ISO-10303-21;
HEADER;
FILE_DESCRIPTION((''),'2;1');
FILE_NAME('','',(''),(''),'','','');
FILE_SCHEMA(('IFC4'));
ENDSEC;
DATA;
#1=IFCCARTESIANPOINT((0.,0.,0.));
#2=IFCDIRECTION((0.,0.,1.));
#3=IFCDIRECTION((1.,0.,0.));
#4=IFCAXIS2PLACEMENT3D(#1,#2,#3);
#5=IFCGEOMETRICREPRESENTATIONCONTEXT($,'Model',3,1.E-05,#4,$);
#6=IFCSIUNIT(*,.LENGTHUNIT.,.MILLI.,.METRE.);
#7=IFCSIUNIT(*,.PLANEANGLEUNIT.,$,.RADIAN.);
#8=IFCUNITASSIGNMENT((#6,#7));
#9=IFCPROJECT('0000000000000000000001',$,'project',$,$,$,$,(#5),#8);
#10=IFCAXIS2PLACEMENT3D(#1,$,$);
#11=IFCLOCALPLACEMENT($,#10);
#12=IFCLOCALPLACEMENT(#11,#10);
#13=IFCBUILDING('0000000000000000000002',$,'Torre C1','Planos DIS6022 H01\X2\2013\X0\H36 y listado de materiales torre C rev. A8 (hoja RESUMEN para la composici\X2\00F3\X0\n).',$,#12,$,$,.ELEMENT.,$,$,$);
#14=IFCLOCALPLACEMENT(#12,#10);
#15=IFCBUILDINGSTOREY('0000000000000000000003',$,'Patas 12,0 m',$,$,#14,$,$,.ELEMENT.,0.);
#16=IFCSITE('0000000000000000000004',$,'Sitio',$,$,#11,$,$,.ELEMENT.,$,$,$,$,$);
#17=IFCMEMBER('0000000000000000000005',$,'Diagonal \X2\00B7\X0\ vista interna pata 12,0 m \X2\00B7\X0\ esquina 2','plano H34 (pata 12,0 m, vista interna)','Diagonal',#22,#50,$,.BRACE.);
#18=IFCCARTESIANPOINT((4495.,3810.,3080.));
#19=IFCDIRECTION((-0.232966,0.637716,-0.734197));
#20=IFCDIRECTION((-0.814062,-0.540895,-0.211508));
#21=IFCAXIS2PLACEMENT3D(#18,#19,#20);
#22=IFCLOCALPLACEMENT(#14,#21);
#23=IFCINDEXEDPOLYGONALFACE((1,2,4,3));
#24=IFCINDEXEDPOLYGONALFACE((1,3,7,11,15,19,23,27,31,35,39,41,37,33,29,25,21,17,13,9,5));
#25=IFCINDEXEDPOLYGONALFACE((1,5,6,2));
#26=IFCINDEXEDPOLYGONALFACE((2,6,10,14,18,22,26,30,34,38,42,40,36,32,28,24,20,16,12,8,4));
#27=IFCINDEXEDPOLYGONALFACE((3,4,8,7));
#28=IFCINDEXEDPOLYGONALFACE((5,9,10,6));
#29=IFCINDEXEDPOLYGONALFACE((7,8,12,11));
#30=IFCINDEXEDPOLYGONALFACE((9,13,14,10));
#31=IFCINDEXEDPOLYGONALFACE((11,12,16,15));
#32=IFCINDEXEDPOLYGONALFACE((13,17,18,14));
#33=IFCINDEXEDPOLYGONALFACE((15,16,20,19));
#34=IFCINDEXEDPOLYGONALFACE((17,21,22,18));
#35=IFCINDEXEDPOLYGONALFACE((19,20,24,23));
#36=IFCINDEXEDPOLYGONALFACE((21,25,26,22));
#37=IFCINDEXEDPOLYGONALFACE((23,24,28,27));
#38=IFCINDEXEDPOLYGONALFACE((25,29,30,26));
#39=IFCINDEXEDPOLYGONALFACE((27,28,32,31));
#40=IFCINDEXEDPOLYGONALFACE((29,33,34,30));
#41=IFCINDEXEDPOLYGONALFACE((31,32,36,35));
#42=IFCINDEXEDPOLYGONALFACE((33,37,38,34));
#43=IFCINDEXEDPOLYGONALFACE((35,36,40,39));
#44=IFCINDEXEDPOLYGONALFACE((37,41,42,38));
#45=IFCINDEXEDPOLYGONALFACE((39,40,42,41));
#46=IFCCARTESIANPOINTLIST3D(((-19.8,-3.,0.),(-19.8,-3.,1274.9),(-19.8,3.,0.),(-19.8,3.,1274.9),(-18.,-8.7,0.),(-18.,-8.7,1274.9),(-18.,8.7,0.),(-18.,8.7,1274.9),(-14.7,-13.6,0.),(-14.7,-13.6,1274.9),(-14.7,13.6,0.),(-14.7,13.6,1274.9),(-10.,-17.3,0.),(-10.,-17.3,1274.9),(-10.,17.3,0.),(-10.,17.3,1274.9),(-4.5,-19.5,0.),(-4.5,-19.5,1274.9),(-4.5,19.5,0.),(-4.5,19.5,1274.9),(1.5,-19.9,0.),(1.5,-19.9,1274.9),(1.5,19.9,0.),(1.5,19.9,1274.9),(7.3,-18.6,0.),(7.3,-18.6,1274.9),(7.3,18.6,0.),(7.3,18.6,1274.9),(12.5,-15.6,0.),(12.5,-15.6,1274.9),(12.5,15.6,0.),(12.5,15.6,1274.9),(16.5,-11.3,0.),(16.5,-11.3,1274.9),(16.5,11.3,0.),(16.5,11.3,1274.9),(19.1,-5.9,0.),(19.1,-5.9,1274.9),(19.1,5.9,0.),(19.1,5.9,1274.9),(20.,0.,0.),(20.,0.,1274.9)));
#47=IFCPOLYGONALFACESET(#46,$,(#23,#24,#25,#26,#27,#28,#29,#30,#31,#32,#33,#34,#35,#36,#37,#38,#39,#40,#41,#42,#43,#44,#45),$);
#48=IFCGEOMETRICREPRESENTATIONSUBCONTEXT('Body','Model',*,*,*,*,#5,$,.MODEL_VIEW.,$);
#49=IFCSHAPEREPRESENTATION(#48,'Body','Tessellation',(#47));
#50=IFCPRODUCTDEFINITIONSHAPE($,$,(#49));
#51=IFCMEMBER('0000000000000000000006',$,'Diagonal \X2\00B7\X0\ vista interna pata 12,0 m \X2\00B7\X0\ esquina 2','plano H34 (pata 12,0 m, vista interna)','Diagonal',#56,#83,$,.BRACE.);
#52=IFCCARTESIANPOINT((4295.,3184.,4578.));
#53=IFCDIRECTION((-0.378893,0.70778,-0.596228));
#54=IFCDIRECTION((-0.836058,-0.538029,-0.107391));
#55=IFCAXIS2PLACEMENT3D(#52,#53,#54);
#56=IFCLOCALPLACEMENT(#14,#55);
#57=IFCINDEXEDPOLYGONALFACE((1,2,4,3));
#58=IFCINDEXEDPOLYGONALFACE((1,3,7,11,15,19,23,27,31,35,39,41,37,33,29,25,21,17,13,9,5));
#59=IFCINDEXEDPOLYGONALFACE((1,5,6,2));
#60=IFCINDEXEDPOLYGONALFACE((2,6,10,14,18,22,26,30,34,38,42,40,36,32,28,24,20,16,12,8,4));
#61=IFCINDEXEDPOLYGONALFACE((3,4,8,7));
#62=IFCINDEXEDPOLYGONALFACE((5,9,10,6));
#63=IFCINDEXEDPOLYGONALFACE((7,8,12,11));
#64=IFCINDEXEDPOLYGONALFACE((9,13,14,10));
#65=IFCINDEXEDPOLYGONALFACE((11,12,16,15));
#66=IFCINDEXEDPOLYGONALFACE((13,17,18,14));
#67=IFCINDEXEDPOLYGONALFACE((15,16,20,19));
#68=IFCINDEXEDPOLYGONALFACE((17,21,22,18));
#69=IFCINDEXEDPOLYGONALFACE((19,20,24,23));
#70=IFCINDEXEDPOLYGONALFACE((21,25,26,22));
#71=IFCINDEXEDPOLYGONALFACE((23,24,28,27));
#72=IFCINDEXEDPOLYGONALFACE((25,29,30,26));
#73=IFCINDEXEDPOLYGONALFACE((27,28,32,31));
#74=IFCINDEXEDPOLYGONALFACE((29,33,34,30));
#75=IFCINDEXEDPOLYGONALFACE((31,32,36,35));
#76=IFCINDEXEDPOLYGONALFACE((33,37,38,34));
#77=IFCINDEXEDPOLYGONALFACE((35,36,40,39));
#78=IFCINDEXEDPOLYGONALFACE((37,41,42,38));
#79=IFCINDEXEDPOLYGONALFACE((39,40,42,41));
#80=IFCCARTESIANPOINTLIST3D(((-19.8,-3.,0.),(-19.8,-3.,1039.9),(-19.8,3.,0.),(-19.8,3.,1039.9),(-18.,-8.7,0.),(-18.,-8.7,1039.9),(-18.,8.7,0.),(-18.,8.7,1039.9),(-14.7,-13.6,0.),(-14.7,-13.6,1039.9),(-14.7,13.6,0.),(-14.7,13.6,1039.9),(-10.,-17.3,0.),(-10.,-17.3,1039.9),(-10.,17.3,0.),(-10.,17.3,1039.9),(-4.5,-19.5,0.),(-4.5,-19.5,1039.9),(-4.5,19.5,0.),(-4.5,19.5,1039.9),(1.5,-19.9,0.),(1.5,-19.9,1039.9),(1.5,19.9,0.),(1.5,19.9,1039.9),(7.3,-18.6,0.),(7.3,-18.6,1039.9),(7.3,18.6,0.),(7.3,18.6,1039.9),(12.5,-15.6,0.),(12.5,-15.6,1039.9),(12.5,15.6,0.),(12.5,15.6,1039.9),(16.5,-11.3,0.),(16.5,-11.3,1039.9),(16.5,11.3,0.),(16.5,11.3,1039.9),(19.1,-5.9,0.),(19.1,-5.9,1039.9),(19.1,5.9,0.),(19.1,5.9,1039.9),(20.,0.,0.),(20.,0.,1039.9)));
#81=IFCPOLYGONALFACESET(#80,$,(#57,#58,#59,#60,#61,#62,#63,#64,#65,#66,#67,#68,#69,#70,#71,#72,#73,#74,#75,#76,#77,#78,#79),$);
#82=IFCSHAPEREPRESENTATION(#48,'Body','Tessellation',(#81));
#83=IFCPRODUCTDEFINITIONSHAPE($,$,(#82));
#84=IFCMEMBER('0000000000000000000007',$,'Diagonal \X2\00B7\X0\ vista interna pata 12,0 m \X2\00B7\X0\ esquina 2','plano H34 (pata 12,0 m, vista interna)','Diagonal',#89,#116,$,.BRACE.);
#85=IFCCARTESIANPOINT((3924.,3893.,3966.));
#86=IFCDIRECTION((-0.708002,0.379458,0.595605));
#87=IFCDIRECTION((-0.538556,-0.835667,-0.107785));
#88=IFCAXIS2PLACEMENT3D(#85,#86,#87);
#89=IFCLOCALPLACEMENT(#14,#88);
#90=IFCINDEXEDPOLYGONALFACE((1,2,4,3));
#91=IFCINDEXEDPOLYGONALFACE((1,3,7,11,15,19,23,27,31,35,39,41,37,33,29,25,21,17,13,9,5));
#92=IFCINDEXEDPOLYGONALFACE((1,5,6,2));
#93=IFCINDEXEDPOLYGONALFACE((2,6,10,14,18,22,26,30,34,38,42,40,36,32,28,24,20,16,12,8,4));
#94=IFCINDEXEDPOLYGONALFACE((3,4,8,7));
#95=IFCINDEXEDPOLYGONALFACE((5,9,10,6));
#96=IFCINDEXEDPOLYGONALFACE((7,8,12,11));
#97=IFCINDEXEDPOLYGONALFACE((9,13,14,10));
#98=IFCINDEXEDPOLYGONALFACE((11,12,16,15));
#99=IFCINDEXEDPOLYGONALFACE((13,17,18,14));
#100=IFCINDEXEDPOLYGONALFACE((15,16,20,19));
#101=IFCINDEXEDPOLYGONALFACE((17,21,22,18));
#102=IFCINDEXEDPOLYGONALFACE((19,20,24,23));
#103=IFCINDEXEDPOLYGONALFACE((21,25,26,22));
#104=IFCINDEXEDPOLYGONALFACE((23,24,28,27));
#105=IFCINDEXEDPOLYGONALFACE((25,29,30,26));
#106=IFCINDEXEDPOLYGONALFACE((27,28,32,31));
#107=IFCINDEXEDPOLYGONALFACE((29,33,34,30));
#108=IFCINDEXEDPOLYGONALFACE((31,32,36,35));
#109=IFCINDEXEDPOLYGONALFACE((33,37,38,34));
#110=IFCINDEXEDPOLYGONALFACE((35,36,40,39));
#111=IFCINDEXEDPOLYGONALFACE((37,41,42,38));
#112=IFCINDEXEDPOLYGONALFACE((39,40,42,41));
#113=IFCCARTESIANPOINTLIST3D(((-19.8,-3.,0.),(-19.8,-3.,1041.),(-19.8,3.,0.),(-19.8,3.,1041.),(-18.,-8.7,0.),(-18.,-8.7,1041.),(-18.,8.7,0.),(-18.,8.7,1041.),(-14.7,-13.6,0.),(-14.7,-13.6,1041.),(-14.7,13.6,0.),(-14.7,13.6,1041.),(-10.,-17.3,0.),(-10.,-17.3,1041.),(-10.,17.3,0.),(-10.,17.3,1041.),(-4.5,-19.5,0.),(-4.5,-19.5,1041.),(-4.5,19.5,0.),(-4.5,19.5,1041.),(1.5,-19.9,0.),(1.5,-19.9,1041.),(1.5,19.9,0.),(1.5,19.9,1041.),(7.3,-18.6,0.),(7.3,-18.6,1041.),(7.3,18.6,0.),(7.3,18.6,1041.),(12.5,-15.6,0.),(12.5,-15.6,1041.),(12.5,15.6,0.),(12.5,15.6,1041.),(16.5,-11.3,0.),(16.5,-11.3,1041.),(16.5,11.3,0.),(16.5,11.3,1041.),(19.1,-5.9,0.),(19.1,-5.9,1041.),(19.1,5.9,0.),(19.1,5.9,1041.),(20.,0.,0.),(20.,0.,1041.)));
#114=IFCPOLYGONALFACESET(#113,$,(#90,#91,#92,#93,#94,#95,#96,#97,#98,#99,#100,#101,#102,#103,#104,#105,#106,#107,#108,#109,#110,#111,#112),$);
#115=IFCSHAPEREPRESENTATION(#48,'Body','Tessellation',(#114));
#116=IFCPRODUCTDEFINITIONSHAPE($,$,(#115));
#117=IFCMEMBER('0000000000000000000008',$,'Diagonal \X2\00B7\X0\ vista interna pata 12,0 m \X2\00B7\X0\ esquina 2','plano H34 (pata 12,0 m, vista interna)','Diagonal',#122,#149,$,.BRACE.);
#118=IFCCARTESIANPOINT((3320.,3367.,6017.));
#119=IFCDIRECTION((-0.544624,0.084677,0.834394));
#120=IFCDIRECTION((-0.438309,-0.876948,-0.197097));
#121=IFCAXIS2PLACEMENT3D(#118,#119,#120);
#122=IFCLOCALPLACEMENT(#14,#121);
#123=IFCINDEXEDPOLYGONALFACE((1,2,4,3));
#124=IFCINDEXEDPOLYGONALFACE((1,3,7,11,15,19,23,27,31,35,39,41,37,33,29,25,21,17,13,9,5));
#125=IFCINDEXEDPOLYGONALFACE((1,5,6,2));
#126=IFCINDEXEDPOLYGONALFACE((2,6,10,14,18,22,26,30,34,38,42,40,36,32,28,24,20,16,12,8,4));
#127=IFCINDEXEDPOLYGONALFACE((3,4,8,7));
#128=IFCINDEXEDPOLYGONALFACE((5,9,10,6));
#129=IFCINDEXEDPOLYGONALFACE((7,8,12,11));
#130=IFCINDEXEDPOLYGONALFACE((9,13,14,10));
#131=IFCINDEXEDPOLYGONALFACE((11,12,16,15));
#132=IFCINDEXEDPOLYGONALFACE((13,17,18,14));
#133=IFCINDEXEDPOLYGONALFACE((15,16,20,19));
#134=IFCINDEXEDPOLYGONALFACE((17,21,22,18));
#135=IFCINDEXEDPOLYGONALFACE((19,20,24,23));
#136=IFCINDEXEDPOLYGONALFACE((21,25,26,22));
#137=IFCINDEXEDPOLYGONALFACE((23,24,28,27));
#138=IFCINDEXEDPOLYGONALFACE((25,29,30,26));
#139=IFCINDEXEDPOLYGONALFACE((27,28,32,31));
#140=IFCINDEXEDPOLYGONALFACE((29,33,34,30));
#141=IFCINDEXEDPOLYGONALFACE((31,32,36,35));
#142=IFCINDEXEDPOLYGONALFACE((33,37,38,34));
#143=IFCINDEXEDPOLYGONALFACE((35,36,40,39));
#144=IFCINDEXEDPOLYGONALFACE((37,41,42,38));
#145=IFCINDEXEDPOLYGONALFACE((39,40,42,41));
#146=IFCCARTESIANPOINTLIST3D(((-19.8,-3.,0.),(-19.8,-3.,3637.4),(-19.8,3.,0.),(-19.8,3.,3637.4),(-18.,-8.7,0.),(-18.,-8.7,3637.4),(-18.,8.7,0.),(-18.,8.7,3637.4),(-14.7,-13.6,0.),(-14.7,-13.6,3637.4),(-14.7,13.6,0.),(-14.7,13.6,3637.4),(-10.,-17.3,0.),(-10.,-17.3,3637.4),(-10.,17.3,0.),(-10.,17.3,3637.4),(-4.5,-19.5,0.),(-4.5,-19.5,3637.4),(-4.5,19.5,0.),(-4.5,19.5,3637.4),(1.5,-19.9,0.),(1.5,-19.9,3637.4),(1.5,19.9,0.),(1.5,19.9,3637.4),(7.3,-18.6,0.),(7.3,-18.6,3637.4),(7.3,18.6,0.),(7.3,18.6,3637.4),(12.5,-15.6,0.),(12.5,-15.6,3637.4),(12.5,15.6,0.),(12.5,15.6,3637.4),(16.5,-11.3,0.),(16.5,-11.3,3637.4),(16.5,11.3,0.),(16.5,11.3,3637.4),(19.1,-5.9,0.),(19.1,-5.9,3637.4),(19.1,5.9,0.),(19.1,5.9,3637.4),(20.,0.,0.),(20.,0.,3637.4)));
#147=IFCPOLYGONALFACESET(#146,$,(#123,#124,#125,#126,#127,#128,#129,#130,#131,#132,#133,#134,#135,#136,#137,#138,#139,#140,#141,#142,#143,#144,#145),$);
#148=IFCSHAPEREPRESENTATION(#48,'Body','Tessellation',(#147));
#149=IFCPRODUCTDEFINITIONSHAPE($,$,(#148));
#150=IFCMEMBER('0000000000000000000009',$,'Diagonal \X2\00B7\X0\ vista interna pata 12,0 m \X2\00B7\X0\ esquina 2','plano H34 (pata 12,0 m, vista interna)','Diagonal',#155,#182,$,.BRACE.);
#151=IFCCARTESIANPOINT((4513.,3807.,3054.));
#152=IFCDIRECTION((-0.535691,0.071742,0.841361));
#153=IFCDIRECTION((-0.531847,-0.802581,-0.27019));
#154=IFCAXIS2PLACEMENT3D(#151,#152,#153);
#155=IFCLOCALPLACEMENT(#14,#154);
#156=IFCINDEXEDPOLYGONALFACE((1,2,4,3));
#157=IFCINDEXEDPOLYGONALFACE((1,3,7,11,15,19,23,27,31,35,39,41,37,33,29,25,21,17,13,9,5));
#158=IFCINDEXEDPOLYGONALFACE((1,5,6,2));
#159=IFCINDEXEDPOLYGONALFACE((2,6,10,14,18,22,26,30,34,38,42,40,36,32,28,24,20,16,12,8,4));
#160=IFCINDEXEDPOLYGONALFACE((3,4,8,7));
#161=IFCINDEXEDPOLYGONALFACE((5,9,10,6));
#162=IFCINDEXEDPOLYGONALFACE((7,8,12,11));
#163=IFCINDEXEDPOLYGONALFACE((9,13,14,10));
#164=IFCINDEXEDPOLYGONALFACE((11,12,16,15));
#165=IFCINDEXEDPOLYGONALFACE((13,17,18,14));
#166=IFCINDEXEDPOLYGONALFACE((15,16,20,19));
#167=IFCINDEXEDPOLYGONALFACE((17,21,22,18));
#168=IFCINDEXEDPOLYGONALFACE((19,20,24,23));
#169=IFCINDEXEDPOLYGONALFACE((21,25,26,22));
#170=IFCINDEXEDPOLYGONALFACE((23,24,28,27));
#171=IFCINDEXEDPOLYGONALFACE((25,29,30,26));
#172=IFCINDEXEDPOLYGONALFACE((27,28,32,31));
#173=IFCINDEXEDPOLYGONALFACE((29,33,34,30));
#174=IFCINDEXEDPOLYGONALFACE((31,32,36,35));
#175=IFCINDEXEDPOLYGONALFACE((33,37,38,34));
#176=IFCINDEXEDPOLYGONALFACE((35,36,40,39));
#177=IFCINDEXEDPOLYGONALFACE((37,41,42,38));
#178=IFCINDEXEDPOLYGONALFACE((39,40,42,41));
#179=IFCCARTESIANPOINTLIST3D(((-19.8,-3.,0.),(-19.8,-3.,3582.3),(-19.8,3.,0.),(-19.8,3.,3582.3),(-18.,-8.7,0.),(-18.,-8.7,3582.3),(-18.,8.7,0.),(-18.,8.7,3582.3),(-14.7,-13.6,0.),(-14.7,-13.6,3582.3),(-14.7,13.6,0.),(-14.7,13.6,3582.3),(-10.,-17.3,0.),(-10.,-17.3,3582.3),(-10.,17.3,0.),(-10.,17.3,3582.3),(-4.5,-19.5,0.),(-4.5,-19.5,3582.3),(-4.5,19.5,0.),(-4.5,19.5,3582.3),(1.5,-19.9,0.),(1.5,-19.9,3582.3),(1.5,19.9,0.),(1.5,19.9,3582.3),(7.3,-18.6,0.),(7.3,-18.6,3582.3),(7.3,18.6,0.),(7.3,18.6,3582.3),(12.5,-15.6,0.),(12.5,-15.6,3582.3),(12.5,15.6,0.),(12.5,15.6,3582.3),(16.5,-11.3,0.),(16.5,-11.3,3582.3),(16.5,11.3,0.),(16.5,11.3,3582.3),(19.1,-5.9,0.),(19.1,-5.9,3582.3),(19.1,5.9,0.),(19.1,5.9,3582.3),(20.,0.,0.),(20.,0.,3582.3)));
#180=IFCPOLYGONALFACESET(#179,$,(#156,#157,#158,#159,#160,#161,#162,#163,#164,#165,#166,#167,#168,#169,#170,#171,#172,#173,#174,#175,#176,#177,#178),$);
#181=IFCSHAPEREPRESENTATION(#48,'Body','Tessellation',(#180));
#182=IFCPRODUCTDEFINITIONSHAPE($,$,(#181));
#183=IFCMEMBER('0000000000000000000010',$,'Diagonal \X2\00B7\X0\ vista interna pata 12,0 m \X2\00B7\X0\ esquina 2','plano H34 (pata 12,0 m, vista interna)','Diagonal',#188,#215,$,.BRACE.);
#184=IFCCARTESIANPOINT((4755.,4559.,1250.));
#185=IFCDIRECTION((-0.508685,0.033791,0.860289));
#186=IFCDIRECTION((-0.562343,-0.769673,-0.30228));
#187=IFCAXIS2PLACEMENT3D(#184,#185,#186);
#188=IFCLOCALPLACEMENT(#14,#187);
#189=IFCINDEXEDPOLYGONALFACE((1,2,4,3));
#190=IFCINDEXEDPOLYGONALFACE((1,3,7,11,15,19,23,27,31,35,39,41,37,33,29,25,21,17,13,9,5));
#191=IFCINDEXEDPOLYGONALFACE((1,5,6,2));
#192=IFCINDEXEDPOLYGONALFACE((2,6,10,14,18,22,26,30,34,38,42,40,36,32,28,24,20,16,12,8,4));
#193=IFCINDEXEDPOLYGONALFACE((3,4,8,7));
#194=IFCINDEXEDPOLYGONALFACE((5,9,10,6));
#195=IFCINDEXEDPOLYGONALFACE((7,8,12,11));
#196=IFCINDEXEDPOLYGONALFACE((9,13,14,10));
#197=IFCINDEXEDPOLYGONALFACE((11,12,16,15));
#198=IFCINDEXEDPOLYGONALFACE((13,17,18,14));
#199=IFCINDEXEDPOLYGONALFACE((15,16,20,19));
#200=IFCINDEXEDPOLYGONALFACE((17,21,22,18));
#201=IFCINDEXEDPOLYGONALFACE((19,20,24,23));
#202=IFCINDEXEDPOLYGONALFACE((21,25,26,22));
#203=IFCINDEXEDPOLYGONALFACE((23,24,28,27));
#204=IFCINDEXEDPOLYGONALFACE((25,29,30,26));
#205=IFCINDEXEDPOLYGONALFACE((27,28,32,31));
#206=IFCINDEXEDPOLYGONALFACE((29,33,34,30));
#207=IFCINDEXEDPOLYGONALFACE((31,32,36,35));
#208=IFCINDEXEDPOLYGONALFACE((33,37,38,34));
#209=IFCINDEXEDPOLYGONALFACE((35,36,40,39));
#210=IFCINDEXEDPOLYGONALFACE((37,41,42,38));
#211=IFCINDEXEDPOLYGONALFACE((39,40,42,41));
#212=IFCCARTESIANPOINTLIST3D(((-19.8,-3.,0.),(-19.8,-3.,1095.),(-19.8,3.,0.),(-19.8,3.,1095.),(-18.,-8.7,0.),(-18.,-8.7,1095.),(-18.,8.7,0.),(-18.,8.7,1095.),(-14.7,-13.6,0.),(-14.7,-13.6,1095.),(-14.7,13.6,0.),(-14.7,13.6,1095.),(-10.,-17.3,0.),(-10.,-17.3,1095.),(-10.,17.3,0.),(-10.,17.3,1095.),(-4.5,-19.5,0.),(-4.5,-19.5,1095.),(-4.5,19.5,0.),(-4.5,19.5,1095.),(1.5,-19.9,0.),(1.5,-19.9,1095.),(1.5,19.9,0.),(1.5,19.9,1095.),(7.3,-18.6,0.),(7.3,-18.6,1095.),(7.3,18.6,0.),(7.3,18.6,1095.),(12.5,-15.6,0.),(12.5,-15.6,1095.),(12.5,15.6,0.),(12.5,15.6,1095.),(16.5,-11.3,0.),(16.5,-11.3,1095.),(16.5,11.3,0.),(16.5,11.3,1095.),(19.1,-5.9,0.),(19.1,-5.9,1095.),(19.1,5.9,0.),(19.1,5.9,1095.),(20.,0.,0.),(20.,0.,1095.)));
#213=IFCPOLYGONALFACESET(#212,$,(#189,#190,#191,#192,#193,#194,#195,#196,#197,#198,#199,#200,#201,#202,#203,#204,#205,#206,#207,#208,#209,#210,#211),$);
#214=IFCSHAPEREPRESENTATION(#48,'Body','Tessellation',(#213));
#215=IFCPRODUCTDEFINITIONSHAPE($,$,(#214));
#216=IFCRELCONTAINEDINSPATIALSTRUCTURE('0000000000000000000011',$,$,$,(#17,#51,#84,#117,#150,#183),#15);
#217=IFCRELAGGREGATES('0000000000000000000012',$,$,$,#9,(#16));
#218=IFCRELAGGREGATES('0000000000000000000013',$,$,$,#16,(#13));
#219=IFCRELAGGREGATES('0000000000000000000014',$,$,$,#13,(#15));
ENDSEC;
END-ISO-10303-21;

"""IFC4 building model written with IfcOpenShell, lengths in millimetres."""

from ifc_helpers import new_model, si_unit, frame, origin, origin_with_axes, place, context, subcontext, project, spatial, circle, extrude, element, save


model = new_model("IFC4")

# Units and contexts
model_context = context("Model", 3, precision=1e-05, world=origin_with_axes())
body_context = subcontext(model_context, "Body", "Model", "MODEL_VIEW")
ifc_project = project(units=[si_unit("LENGTHUNIT", "METRE", prefix="MILLI"), si_unit("PLANEANGLEUNIT", "RADIAN")], contexts=[model_context])

# Site, building, storey
site_placement = place(None, origin())
site = spatial("IfcSite", under=ifc_project, at=site_placement, Name="Sitio", CompositionType="ELEMENT")
building_placement = place(site_placement, origin())
building = spatial("IfcBuilding", under=site, at=building_placement, Name="Torre C1", Description="Planos DIS6022 H01–H36 y listado de materiales torre C rev. A8 (hoja RESUMEN para la composición).", CompositionType="ELEMENT")
storey_placement = place(building_placement, origin())
storey = spatial("IfcBuildingStorey", under=building, at=storey_placement, Name="Patas 12,0 m", CompositionType="ELEMENT", Elevation=0.0)

# Members
member_1_placement = place(storey_placement, frame((4495.0, 3810.0, 3080.0), z_axis=(-0.232966, 0.637716, -0.734197), x_axis=(-0.814062, -0.540895, -0.211508)))
element("IfcMember", 1, at=member_1_placement, inside=storey, Name="Diagonal · vista interna pata 12,0 m · esquina 2", Description="plano H34 (pata 12,0 m, vista interna)", ObjectType="Diagonal", PredefinedType="BRACE", context=body_context, shape_type="SweptSolid", body=[
    extrude(circle(Radius=20.0), None, (0.0, 0.0, 1.0), 1274.9),
])
member_2_placement = place(storey_placement, frame((4295.0, 3184.0, 4578.0), z_axis=(-0.378893, 0.70778, -0.596228), x_axis=(-0.836058, -0.538029, -0.107391)))
element("IfcMember", 2, at=member_2_placement, inside=storey, Name="Diagonal · vista interna pata 12,0 m · esquina 2", Description="plano H34 (pata 12,0 m, vista interna)", ObjectType="Diagonal", PredefinedType="BRACE", context=body_context, shape_type="SweptSolid", body=[
    extrude(circle(Radius=20.0), None, (0.0, 0.0, 1.0), 1039.9),
])
member_3_placement = place(storey_placement, frame((3924.0, 3893.0, 3966.0), z_axis=(-0.708002, 0.379458, 0.595605), x_axis=(-0.538556, -0.835667, -0.107785)))
element("IfcMember", 3, at=member_3_placement, inside=storey, Name="Diagonal · vista interna pata 12,0 m · esquina 2", Description="plano H34 (pata 12,0 m, vista interna)", ObjectType="Diagonal", PredefinedType="BRACE", context=body_context, shape_type="SweptSolid", body=[
    extrude(circle(Radius=20.0), None, (0.0, 0.0, 1.0), 1041.0),
])
member_4_placement = place(storey_placement, frame((3320.0, 3367.0, 6017.0), z_axis=(-0.544624, 0.084677, 0.834394), x_axis=(-0.438309, -0.876948, -0.197097)))
element("IfcMember", 4, at=member_4_placement, inside=storey, Name="Diagonal · vista interna pata 12,0 m · esquina 2", Description="plano H34 (pata 12,0 m, vista interna)", ObjectType="Diagonal", PredefinedType="BRACE", context=body_context, shape_type="SweptSolid", body=[
    extrude(circle(Radius=20.0), None, (0.0, 0.0, 1.0), 3637.4),
])
member_5_placement = place(storey_placement, frame((4513.0, 3807.0, 3054.0), z_axis=(-0.535691, 0.071742, 0.841361), x_axis=(-0.531847, -0.802581, -0.27019)))
element("IfcMember", 5, at=member_5_placement, inside=storey, Name="Diagonal · vista interna pata 12,0 m · esquina 2", Description="plano H34 (pata 12,0 m, vista interna)", ObjectType="Diagonal", PredefinedType="BRACE", context=body_context, shape_type="SweptSolid", body=[
    extrude(circle(Radius=20.0), None, (0.0, 0.0, 1.0), 3582.3),
])
member_6_placement = place(storey_placement, frame((4755.0, 4559.0, 1250.0), z_axis=(-0.508685, 0.033791, 0.860289), x_axis=(-0.562343, -0.769673, -0.30228)))
element("IfcMember", 6, at=member_6_placement, inside=storey, Name="Diagonal · vista interna pata 12,0 m · esquina 2", Description="plano H34 (pata 12,0 m, vista interna)", ObjectType="Diagonal", PredefinedType="BRACE", context=body_context, shape_type="SweptSolid", body=[
    extrude(circle(Radius=20.0), None, (0.0, 0.0, 1.0), 1095.0),
])

save(model, "model.ifc")
